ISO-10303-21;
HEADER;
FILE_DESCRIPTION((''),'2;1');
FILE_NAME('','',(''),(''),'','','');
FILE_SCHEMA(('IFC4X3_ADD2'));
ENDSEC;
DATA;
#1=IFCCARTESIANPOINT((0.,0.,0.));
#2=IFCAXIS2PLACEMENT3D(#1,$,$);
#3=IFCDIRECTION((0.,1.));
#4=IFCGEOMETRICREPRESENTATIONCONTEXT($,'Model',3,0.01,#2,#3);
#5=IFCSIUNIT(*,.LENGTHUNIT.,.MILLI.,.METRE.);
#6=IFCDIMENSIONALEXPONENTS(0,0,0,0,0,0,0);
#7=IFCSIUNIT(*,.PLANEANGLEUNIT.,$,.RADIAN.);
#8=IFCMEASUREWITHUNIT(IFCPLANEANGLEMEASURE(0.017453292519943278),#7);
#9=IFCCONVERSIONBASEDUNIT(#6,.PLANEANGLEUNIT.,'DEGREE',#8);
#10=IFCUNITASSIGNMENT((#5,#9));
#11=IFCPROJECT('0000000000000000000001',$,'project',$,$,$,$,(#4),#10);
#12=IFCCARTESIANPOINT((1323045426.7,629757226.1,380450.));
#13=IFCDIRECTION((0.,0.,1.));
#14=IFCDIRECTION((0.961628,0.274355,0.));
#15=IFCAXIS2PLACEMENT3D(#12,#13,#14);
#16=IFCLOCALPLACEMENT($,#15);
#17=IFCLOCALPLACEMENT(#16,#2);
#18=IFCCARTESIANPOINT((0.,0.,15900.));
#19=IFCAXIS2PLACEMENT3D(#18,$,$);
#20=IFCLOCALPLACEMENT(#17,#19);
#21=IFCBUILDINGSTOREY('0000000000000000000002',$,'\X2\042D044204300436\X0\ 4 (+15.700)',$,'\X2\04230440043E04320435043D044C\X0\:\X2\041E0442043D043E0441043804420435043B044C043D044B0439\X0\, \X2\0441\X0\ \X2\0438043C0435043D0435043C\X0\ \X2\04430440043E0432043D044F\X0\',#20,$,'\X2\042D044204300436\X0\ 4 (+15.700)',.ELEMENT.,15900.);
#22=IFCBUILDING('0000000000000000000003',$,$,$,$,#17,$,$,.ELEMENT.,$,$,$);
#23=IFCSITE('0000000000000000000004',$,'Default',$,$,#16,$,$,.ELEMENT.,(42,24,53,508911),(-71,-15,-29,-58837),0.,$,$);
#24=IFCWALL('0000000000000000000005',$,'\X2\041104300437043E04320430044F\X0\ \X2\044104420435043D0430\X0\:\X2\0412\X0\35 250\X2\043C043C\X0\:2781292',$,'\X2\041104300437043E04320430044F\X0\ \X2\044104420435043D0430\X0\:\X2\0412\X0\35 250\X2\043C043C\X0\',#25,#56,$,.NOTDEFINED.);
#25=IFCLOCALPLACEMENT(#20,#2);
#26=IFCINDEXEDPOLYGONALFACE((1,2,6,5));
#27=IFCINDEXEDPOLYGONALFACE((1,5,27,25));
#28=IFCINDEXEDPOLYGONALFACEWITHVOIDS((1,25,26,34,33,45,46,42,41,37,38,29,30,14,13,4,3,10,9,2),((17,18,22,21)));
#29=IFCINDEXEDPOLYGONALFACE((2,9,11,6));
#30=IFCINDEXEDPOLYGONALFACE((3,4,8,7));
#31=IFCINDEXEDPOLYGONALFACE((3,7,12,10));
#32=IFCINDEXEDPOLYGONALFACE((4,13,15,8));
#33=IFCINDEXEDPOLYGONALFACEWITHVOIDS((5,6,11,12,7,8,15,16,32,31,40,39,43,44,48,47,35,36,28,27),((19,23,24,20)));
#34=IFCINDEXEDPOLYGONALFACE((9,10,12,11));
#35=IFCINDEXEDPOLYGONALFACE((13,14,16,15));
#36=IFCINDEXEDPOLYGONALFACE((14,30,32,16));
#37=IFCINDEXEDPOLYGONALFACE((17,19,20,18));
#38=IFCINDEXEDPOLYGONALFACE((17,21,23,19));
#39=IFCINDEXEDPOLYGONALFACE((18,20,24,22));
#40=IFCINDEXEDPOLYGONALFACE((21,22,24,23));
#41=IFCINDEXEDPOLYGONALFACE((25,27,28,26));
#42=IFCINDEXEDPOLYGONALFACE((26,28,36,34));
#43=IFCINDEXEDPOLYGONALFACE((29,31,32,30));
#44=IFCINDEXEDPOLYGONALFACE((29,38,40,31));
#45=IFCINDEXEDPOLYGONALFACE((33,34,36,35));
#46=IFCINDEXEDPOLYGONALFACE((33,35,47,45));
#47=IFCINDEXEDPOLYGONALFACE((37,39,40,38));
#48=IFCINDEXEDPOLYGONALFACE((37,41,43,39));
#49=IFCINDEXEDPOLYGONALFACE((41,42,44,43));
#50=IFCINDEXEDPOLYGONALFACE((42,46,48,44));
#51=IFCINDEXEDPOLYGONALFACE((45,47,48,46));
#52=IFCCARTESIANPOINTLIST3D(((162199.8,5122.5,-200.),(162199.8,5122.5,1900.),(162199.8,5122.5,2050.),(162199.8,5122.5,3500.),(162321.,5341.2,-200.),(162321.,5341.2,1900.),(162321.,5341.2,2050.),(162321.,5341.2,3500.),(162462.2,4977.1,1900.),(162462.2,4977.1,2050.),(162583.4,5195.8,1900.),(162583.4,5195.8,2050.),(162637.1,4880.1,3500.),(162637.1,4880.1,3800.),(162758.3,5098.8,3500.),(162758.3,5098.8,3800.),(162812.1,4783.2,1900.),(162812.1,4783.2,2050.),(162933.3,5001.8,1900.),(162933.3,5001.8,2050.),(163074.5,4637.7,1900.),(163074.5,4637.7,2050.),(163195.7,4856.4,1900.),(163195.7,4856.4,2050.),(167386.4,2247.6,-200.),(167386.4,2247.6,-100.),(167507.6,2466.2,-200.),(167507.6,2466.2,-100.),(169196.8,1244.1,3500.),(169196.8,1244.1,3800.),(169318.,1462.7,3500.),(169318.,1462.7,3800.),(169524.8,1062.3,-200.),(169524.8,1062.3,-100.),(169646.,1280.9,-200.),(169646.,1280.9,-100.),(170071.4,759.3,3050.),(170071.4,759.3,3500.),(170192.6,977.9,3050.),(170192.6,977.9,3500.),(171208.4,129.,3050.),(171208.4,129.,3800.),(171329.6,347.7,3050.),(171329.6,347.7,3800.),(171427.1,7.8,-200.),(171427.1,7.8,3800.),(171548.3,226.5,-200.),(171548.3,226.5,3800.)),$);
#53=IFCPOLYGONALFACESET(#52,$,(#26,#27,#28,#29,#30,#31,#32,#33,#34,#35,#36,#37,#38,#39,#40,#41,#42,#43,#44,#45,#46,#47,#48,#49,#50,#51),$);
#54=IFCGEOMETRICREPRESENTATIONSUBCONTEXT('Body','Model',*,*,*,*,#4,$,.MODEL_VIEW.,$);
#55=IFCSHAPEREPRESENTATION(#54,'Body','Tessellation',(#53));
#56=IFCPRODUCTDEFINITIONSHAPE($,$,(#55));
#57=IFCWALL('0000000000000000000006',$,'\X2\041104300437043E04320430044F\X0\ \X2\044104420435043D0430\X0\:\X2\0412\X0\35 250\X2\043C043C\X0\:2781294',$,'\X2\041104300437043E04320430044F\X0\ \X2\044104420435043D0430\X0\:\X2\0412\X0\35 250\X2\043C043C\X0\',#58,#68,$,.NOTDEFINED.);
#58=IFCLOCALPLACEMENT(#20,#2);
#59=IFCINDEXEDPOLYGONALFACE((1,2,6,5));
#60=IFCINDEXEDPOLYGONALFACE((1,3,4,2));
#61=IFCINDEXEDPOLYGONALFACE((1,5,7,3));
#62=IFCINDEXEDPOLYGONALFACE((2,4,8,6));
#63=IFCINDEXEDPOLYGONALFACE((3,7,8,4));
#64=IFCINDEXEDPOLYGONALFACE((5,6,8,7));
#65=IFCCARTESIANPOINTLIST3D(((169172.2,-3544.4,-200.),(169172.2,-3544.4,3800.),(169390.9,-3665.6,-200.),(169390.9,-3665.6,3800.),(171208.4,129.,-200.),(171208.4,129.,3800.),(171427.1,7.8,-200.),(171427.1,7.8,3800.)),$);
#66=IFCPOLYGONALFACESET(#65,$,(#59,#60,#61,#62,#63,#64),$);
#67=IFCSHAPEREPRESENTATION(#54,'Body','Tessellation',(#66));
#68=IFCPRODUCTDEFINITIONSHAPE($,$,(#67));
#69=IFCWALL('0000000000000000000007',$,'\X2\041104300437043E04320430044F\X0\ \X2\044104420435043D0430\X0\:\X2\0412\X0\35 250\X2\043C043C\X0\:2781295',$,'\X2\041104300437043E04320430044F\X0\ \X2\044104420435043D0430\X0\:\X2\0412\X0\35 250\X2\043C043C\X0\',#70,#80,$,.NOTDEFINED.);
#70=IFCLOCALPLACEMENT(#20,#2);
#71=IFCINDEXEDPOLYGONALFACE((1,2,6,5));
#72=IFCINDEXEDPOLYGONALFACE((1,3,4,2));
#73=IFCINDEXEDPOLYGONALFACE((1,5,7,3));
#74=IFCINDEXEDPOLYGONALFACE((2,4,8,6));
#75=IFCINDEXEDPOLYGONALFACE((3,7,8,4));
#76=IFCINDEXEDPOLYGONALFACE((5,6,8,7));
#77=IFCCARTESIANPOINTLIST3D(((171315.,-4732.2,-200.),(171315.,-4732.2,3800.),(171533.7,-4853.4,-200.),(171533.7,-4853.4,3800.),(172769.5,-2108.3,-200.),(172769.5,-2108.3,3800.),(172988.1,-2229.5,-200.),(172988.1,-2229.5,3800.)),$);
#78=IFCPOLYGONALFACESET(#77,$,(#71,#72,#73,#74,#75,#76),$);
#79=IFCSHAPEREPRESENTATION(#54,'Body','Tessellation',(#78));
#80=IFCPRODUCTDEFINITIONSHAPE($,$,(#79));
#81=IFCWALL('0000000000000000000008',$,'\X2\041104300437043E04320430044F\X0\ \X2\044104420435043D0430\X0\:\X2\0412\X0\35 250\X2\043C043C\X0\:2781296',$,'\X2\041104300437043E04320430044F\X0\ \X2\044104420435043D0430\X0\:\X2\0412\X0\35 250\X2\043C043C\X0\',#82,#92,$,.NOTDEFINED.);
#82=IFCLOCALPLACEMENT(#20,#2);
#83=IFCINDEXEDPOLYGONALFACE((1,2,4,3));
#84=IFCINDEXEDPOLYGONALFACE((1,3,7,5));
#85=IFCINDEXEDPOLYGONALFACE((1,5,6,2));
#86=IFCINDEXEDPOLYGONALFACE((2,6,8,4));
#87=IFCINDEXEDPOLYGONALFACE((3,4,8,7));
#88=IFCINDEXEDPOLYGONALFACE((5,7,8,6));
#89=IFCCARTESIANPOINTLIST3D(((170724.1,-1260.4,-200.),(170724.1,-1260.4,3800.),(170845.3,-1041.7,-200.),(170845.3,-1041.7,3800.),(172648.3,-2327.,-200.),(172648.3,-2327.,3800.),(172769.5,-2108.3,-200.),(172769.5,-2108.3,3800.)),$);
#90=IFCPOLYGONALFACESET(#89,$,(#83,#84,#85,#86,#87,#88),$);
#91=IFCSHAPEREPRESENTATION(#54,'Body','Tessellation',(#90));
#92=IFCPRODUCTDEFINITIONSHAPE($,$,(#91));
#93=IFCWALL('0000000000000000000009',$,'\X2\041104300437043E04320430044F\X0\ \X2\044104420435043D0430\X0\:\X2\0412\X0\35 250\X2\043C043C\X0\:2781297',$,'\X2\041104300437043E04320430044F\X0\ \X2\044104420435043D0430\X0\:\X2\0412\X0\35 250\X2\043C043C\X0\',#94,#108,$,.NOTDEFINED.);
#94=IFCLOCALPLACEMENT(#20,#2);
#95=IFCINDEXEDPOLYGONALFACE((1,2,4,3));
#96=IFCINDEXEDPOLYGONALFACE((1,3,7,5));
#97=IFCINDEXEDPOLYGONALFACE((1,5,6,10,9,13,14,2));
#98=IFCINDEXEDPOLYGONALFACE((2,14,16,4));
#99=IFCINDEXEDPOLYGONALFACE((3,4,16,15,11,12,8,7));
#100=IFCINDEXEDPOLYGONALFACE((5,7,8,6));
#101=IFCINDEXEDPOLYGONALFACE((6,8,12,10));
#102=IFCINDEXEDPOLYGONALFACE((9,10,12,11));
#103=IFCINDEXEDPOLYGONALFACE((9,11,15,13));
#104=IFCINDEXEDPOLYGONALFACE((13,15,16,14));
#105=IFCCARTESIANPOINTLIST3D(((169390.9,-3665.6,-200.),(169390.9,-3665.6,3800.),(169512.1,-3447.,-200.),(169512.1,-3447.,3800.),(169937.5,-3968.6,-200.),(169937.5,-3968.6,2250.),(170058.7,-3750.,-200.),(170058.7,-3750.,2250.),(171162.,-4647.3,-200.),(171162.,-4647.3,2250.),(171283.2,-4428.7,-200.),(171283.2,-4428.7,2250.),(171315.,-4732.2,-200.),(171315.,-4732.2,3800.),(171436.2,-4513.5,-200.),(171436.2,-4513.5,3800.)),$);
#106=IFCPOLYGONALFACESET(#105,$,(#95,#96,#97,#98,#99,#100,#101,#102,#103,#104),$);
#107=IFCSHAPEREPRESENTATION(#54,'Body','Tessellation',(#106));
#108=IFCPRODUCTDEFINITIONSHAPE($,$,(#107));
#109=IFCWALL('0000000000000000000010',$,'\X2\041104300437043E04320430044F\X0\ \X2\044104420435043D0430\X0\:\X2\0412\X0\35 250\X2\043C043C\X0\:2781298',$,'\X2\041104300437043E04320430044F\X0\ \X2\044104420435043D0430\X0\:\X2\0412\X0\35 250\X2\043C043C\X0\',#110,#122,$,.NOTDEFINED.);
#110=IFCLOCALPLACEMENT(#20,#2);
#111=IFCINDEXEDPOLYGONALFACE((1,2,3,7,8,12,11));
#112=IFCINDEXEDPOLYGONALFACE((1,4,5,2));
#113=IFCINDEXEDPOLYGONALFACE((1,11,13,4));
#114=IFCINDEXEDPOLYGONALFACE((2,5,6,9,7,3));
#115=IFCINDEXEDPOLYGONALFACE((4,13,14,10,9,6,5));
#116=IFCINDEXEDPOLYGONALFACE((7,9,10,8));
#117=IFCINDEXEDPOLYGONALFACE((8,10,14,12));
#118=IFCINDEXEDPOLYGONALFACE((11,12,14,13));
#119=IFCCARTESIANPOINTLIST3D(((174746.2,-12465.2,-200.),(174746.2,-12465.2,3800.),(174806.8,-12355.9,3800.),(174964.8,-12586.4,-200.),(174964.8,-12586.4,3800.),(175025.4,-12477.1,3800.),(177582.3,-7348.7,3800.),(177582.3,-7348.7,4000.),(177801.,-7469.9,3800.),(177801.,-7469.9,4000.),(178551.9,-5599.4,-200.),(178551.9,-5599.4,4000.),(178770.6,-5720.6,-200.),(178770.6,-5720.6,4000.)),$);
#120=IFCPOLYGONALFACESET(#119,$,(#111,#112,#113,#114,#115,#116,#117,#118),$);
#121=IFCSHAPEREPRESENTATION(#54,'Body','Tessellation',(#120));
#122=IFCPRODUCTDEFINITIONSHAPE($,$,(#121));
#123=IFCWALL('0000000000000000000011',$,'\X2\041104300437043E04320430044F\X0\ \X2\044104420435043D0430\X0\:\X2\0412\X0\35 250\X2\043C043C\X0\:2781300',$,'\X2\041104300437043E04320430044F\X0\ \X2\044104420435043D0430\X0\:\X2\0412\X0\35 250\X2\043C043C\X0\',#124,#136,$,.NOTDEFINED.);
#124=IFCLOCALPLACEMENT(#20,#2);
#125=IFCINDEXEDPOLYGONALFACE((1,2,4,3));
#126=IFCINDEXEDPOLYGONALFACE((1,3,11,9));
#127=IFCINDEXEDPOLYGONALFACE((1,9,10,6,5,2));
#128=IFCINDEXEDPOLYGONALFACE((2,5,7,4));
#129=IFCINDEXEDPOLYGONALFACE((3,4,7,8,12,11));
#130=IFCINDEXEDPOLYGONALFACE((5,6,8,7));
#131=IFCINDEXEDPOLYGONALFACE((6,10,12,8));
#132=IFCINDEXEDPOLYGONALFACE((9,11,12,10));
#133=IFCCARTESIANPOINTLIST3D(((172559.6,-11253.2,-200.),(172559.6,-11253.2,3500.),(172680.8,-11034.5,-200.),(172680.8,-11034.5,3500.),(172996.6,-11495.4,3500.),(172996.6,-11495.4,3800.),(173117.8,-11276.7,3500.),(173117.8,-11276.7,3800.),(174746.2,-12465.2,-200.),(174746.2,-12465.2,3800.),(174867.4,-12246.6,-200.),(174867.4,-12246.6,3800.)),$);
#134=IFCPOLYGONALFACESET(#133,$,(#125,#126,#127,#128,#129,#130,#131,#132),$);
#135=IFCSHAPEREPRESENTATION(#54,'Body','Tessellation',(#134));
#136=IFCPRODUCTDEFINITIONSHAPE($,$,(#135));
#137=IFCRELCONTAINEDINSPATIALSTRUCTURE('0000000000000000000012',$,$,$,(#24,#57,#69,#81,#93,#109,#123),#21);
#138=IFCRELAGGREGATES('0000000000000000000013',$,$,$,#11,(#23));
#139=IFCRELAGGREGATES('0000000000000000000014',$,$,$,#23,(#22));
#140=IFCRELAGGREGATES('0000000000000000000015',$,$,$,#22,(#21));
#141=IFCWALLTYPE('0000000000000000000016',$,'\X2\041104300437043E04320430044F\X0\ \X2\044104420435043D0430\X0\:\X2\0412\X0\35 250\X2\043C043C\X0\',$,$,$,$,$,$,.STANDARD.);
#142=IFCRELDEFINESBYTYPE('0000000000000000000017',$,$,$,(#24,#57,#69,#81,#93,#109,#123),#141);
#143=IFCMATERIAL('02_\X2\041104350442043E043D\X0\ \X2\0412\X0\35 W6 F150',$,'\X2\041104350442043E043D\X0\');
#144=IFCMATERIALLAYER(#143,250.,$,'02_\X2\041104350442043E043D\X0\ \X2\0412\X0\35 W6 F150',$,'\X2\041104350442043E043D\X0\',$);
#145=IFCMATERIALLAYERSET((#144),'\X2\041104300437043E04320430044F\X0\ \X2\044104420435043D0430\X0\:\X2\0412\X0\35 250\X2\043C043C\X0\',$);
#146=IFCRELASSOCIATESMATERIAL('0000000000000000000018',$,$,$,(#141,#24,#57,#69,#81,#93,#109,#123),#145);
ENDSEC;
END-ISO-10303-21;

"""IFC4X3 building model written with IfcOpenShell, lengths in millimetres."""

from ifc_helpers import new_model, entity, si_unit, converted_unit, direction, frame, frame_2d, origin, origin_2d_with_axis, place, context, subcontext, project, spatial, polyline, rectangle, extrude, clip, bounded_halfspace, material, layer, layer_set, type_object, element, save


model = new_model("IFC4X3")

# Units and contexts
model_context = context("Model", 3, precision=0.01, world=origin(), true_north=direction((0.0, 1.0)))
body_context = subcontext(model_context, "Body", "Model", "MODEL_VIEW")
ifc_project = project(units=[si_unit("LENGTHUNIT", "METRE", prefix="MILLI"), converted_unit("PLANEANGLEUNIT", "DEGREE", entity("IfcPlaneAngleMeasure", 0.017453292519943278), si_unit("PLANEANGLEUNIT", "RADIAN"), dimensions=[0, 0, 0, 0, 0, 0, 0])], contexts=[model_context])

# Site, building, storey
site_placement = place(None, frame((1323045426.7, 629757226.1, 380450.0), z_axis=(0.0, 0.0, 1.0), x_axis=(0.961628, 0.274355, 0.0)))
site = spatial("IfcSite", under=ifc_project, at=site_placement, Name="Default", CompositionType="ELEMENT", RefLatitude=(42, 24, 53, 508911), RefLongitude=(-71, -15, -29, -58837), RefElevation=0.0)
building_placement = place(site_placement, origin())
building = spatial("IfcBuilding", under=site, at=building_placement, CompositionType="ELEMENT")
storey_placement = place(building_placement, frame((0.0, 0.0, 15900.0)))
storey = spatial("IfcBuildingStorey", under=building, at=storey_placement, Name="Этаж 4 (+15.700)", ObjectType="Уровень:Относительный, с именем уровня", LongName="Этаж 4 (+15.700)", CompositionType="ELEMENT", Elevation=15900.0)

# Wall, openings
ifc_material = material(Name="02_Бетон В35 W6 F150", Category="Бетон")
ifc_layer_1 = layer(ifc_material, 250.0, Name="02_Бетон В35 W6 F150", Category="Бетон")
ifc_layer_set_1 = layer_set([ifc_layer_1], Name="Базовая стена:В35 250мм")
wall_type_1 = type_object("IfcWallType", Name="Базовая стена:В35 250мм", PredefinedType="STANDARD", material=ifc_layer_set_1)
wall_1_placement = place(storey_placement, frame((171487.7, 117.1, -200.0), z_axis=(0.0, 0.0, 1.0), x_axis=(-0.87462, 0.48481, 0.0)))
wall_1 = element("IfcWall", 1, at=wall_1_placement, inside=storey, type_object=wall_type_1, material=ifc_layer_set_1, Name="Базовая стена:В35 250мм:2781292", ObjectType="Базовая стена:В35 250мм", PredefinedType="NOTDEFINED", context=body_context, shape_type="Clipping", body=[
    clip(clip(extrude(rectangle(XDim=10550.0, YDim=250.0, at=frame_2d((5275.0, 0.0), x_axis=(-1.0, 0.0))), origin(), (0.0, 0.0, 1.0), 4000.0), bounded_halfspace(frame((2550.0, -125.0, 4000.0), z_axis=(0.0, 0.0, -1.0), x_axis=(-0.48481, 0.87462, 0.0)), True, frame((2550.0, -125.0, 4000.0)), polyline([(0.0, 0.0), (7500.0, 0.0), (7500.0, 250.0), (0.0, 250.0), (0.0, 125.0), (0.0, 0.0)]))), bounded_halfspace(frame((0.0, 125.0, 4000.0), z_axis=(0.0, 0.0, -1.0), x_axis=(-0.48481, 0.87462, 0.0)), True, frame((0.0, 125.0, 4000.0)), polyline([(0.0, 0.0), (0.0, -250.0), (250.0, -250.0), (250.0, 0.0), (0.0, 0.0)]))),
])
opening_1_placement = place(wall_1_placement, origin())
element("IfcOpeningElement", 2, at=opening_1_placement, cuts=wall_1, PredefinedType="OPENING", context=body_context, shape_type="SweptSolid", body=[
    extrude(rectangle(XDim=100.0, YDim=2444.9, at=frame_2d((0.0, 0.0), x_axis=(0.0, 1.0))), frame((3397.4, 125.0, 50.0), z_axis=(0.0, -1.0, 0.0), x_axis=(1.0, 0.0, 0.0)), (0.0, 0.0, 1.0), 250.0),
])
opening_2_placement = place(wall_1_placement, origin())
element("IfcOpeningElement", 3, at=opening_2_placement, cuts=wall_1, PredefinedType="OPENING", context=body_context, shape_type="SweptSolid", body=[
    extrude(rectangle(XDim=300.0, YDim=625.0, at=origin_2d_with_axis()), frame((10362.5, 125.0, 3850.0), z_axis=(0.0, -1.0, 0.0), x_axis=(0.0, 0.0, 1.0)), (0.0, 0.0, 1.0), 250.0),
])
opening_3_placement = place(wall_1_placement, origin())
element("IfcOpeningElement", 4, at=opening_3_placement, cuts=wall_1, PredefinedType="OPENING", context=body_context, shape_type="SweptSolid", body=[
    extrude(rectangle(XDim=300.0, YDim=1000.0, at=frame_2d((0.0, 0.0), x_axis=(0.0, 1.0))), frame((2050.0, 125.0, 3850.0), z_axis=(0.0, -1.0, 0.0), x_axis=(-1.0, 0.0, 0.0)), (0.0, 0.0, 1.0), 250.0),
])
opening_4_placement = place(wall_1_placement, frame((149929.7, 83241.3, 2100.0), z_axis=(0.0, 0.0, 1.0), x_axis=(-0.87462, -0.48481, 0.0)))
element("IfcOpeningElement", 5, at=opening_4_placement, cuts=wall_1, PredefinedType="OPENING", context=body_context, shape_type="SweptSolid", body=[
    extrude(rectangle(XDim=150.0, YDim=300.0, at=frame_2d((0.0, 0.0), x_axis=(0.0, 1.0))), frame((163191.1, 6601.4, 75.0), z_axis=(-0.48481, -0.87462, 0.0), x_axis=(-0.87462, 0.48481, 0.0)), (0.0, 0.0, 1.0), 3048.0),
])
opening_5_placement = place(wall_1_placement, frame((149929.7, 83241.3, 3250.0), z_axis=(0.0, 0.0, 1.0), x_axis=(-0.87462, -0.48481, 0.0)))
element("IfcOpeningElement", 6, at=opening_5_placement, cuts=wall_1, PredefinedType="OPENING", context=body_context, shape_type="SweptSolid", body=[
    extrude(rectangle(XDim=750.0, YDim=1300.0, at=frame_2d((0.0, 0.0), x_axis=(1.0, 0.0))), frame((171378.8, 1777.0, 375.0), z_axis=(-0.48481, -0.87462, 0.0), x_axis=(0.0, 0.0, -1.0)), (0.0, 0.0, 1.0), 3048.0),
])
opening_6_placement = place(wall_1_placement, frame((149929.7, 83241.3, 2100.0), z_axis=(0.0, 0.0, 1.0), x_axis=(-0.87462, -0.48481, 0.0)))
element("IfcOpeningElement", 7, at=opening_6_placement, cuts=wall_1, PredefinedType="OPENING", context=body_context, shape_type="SweptSolid", body=[
    extrude(rectangle(XDim=150.0, YDim=300.0, at=frame_2d((0.0, 0.0), x_axis=(0.0, 1.0))), frame((163803.3, 6262.0, 75.0), z_axis=(-0.48481, -0.87462, 0.0), x_axis=(-0.87462, 0.48481, 0.0)), (0.0, 0.0, 1.0), 3048.0),
])

# Walls
wall_2_placement = place(storey_placement, frame((169281.5, -3605.0, -200.0), z_axis=(0.0, 0.0, 1.0), x_axis=(0.48481, 0.87462, 0.0)))
element("IfcWall", 8, at=wall_2_placement, inside=storey, type_object=wall_type_1, material=ifc_layer_set_1, Name="Базовая стена:В35 250мм:2781294", ObjectType="Базовая стена:В35 250мм", PredefinedType="NOTDEFINED", context=body_context, shape_type="SweptSolid", body=[
    extrude(rectangle(XDim=4200.0, YDim=250.0, at=frame_2d((2100.0, 0.0), x_axis=(-1.0, 0.0))), origin(), (0.0, 0.0, 1.0), 4000.0),
])
wall_3_placement = place(storey_placement, frame((171424.4, -4792.8, -200.0), z_axis=(0.0, 0.0, 1.0), x_axis=(0.48481, 0.87462, 0.0)))
element("IfcWall", 9, at=wall_3_placement, inside=storey, type_object=wall_type_1, material=ifc_layer_set_1, Name="Базовая стена:В35 250мм:2781295", ObjectType="Базовая стена:В35 250мм", PredefinedType="NOTDEFINED", context=body_context, shape_type="Clipping", body=[
    clip(extrude(rectangle(XDim=3000.0, YDim=250.0, at=frame_2d((1500.0, 0.0), x_axis=(-1.0, 0.0))), origin(), (0.0, 0.0, 1.0), 4000.0), bounded_halfspace(frame((0.0, -125.0, 4000.0), z_axis=(0.0, 0.0, -1.0), x_axis=(-0.87462, -0.48481, 0.0)), True, frame((0.0, -125.0, 4000.0)), polyline([(0.0, 0.0), (3000.0, 0.0), (3000.0, 250.0), (2750.0, 250.0), (250.0, 250.0), (0.0, 250.0), (0.0, 0.0)]))),
])
wall_4_placement = place(storey_placement, frame((172708.9, -2217.7, -200.0), z_axis=(0.0, 0.0, 1.0), x_axis=(-0.87462, 0.48481, 0.0)))
element("IfcWall", 10, at=wall_4_placement, inside=storey, type_object=wall_type_1, material=ifc_layer_set_1, Name="Базовая стена:В35 250мм:2781296", ObjectType="Базовая стена:В35 250мм", PredefinedType="NOTDEFINED", context=body_context, shape_type="Clipping", body=[
    clip(extrude(rectangle(XDim=2200.0, YDim=250.0, at=frame_2d((1100.0, 0.0), x_axis=(-1.0, 0.0))), origin(), (0.0, 0.0, 1.0), 4000.0), bounded_halfspace(frame((0.0, -125.0, 4000.0), z_axis=(0.0, 0.0, -1.0), x_axis=(-0.48481, 0.87462, 0.0)), True, frame((0.0, -125.0, 4000.0)), polyline([(0.0, 0.0), (2200.0, 0.0), (2200.0, 250.0), (0.0, 250.0), (0.0, 0.0)]))),
])

# Wall, opening
wall_5_placement = place(storey_placement, frame((171375.6, -4622.9, -200.0), z_axis=(0.0, 0.0, 1.0), x_axis=(-0.87462, 0.48481, 0.0)))
wall_5 = element("IfcWall", 11, at=wall_5_placement, inside=storey, type_object=wall_type_1, material=ifc_layer_set_1, Name="Базовая стена:В35 250мм:2781297", ObjectType="Базовая стена:В35 250мм", PredefinedType="NOTDEFINED", context=body_context, shape_type="Clipping", body=[
    clip(extrude(rectangle(XDim=2200.0, YDim=250.0, at=frame_2d((1100.0, 0.0), x_axis=(-1.0, 0.0))), origin(), (0.0, 0.0, 1.0), 4000.0), bounded_halfspace(frame((0.0, -125.0, 4000.0), z_axis=(0.0, 0.0, -1.0), x_axis=(-0.48481, 0.87462, 0.0)), True, frame((0.0, -125.0, 4000.0)), polyline([(0.0, 0.0), (2200.0, 0.0), (2200.0, 250.0), (0.0, 250.0), (0.0, 0.0)]))),
])
opening_7_placement = place(wall_5_placement, frame((152129.7, 79041.3, 0.0), z_axis=(0.0, 0.0, 1.0), x_axis=(-0.87462, -0.48481, 0.0)))
element("IfcOpeningElement", 12, at=opening_7_placement, cuts=wall_5, PredefinedType="OPENING", context=body_context, shape_type="SweptSolid", body=[
    extrude(rectangle(XDim=2450.0, YDim=1400.0, at=frame_2d((0.0, 0.0), x_axis=(1.0, 0.0))), frame((171409.8, -2756.4, 1225.0), z_axis=(-0.48481, -0.87462, 0.0), x_axis=(0.0, 0.0, -1.0)), (0.0, 0.0, 1.0), 3048.0),
])

# Wall, openings
wall_6_placement = place(storey_placement, frame((174855.5, -12525.8, -200.0), z_axis=(0.0, 0.0, 1.0), x_axis=(0.48481, 0.87462, 0.0)))
wall_6 = element("IfcWall", 13, at=wall_6_placement, inside=storey, type_object=wall_type_1, material=ifc_layer_set_1, Name="Базовая стена:В35 250мм:2781298", ObjectType="Базовая стена:В35 250мм", PredefinedType="NOTDEFINED", context=body_context, shape_type="Clipping", body=[
    clip(extrude(rectangle(XDim=7850.0, YDim=250.0, at=frame_2d((3925.0, 0.0), x_axis=(-1.0, 0.0))), origin(), (0.0, 0.0, 1.0), 4200.0), bounded_halfspace(frame((0.0, -125.0, 4000.0), z_axis=(0.0, 0.0, -1.0), x_axis=(-0.87462, -0.48481, 0.0)), True, frame((0.0, -125.0, 4000.0)), polyline([(0.0, 0.0), (5850.0, 0.0), (5850.0, 250.0), (250.0, 250.0), (0.0, 250.0), (0.0, 0.0)]))),
])
opening_8_placement = place(wall_6_placement, origin())
element("IfcOpeningElement", 14, at=opening_8_placement, cuts=wall_6, PredefinedType="OPENING", context=body_context, shape_type="SweptSolid", body=[
    extrude(rectangle(XDim=200.0, YDim=125.0, at=frame_2d((0.0, 0.0), x_axis=(1.0, 0.0))), frame((7912.5, 125.0, 4100.0), z_axis=(0.0, -1.0, 0.0), x_axis=(0.0, 0.0, 1.0)), (0.0, 0.0, 1.0), 250.0),
])
opening_9_placement = place(wall_6_placement, origin())
element("IfcOpeningElement", 15, at=opening_9_placement, cuts=wall_6, PredefinedType="OPENING", context=body_context, shape_type="SweptSolid", body=[
    extrude(rectangle(XDim=200.0, YDim=5725.0, at=frame_2d((0.0, 0.0), x_axis=(0.0, 1.0))), frame((2987.5, 125.0, 4100.0), z_axis=(0.0, -1.0, 0.0), x_axis=(-1.0, 0.0, 0.0)), (0.0, 0.0, 1.0), 250.0),
])

# Wall, opening
wall_7_placement = place(storey_placement, frame((172620.2, -11143.9, -200.0), z_axis=(0.0, 0.0, 1.0), x_axis=(0.87462, -0.48481, 0.0)))
wall_7 = element("IfcWall", 16, at=wall_7_placement, inside=storey, type_object=wall_type_1, material=ifc_layer_set_1, Name="Базовая стена:В35 250мм:2781300", ObjectType="Базовая стена:В35 250мм", PredefinedType="NOTDEFINED", context=body_context, shape_type="Clipping", body=[
    clip(extrude(rectangle(XDim=2500.0, YDim=250.0, at=frame_2d((1250.0, 0.0), x_axis=(-1.0, 0.0))), origin(), (0.0, 0.0, 1.0), 4000.0), bounded_halfspace(frame((499.6, -125.0, 4000.0), z_axis=(0.0, 0.0, -1.0), x_axis=(0.48481, -0.87462, 0.0)), True, frame((499.6, -125.0, 4000.0)), polyline([(0.0, 0.0), (2000.4, 0.0), (2000.4, 250.0), (0.0, 250.0), (0.0, 0.0)]))),
])
opening_10_placement = place(wall_7_placement, origin())
element("IfcOpeningElement", 17, at=opening_10_placement, cuts=wall_7, PredefinedType="OPENING", context=body_context, shape_type="SweptSolid", body=[
    extrude(rectangle(XDim=300.0, YDim=624.6, at=frame_2d((0.0, 0.0), x_axis=(0.0, 1.0))), frame((187.3, 125.0, 3850.0), z_axis=(0.0, -1.0, 0.0), x_axis=(-1.0, 0.0, 0.0)), (0.0, 0.0, 1.0), 250.0),
])

save(model, "model.ifc")
